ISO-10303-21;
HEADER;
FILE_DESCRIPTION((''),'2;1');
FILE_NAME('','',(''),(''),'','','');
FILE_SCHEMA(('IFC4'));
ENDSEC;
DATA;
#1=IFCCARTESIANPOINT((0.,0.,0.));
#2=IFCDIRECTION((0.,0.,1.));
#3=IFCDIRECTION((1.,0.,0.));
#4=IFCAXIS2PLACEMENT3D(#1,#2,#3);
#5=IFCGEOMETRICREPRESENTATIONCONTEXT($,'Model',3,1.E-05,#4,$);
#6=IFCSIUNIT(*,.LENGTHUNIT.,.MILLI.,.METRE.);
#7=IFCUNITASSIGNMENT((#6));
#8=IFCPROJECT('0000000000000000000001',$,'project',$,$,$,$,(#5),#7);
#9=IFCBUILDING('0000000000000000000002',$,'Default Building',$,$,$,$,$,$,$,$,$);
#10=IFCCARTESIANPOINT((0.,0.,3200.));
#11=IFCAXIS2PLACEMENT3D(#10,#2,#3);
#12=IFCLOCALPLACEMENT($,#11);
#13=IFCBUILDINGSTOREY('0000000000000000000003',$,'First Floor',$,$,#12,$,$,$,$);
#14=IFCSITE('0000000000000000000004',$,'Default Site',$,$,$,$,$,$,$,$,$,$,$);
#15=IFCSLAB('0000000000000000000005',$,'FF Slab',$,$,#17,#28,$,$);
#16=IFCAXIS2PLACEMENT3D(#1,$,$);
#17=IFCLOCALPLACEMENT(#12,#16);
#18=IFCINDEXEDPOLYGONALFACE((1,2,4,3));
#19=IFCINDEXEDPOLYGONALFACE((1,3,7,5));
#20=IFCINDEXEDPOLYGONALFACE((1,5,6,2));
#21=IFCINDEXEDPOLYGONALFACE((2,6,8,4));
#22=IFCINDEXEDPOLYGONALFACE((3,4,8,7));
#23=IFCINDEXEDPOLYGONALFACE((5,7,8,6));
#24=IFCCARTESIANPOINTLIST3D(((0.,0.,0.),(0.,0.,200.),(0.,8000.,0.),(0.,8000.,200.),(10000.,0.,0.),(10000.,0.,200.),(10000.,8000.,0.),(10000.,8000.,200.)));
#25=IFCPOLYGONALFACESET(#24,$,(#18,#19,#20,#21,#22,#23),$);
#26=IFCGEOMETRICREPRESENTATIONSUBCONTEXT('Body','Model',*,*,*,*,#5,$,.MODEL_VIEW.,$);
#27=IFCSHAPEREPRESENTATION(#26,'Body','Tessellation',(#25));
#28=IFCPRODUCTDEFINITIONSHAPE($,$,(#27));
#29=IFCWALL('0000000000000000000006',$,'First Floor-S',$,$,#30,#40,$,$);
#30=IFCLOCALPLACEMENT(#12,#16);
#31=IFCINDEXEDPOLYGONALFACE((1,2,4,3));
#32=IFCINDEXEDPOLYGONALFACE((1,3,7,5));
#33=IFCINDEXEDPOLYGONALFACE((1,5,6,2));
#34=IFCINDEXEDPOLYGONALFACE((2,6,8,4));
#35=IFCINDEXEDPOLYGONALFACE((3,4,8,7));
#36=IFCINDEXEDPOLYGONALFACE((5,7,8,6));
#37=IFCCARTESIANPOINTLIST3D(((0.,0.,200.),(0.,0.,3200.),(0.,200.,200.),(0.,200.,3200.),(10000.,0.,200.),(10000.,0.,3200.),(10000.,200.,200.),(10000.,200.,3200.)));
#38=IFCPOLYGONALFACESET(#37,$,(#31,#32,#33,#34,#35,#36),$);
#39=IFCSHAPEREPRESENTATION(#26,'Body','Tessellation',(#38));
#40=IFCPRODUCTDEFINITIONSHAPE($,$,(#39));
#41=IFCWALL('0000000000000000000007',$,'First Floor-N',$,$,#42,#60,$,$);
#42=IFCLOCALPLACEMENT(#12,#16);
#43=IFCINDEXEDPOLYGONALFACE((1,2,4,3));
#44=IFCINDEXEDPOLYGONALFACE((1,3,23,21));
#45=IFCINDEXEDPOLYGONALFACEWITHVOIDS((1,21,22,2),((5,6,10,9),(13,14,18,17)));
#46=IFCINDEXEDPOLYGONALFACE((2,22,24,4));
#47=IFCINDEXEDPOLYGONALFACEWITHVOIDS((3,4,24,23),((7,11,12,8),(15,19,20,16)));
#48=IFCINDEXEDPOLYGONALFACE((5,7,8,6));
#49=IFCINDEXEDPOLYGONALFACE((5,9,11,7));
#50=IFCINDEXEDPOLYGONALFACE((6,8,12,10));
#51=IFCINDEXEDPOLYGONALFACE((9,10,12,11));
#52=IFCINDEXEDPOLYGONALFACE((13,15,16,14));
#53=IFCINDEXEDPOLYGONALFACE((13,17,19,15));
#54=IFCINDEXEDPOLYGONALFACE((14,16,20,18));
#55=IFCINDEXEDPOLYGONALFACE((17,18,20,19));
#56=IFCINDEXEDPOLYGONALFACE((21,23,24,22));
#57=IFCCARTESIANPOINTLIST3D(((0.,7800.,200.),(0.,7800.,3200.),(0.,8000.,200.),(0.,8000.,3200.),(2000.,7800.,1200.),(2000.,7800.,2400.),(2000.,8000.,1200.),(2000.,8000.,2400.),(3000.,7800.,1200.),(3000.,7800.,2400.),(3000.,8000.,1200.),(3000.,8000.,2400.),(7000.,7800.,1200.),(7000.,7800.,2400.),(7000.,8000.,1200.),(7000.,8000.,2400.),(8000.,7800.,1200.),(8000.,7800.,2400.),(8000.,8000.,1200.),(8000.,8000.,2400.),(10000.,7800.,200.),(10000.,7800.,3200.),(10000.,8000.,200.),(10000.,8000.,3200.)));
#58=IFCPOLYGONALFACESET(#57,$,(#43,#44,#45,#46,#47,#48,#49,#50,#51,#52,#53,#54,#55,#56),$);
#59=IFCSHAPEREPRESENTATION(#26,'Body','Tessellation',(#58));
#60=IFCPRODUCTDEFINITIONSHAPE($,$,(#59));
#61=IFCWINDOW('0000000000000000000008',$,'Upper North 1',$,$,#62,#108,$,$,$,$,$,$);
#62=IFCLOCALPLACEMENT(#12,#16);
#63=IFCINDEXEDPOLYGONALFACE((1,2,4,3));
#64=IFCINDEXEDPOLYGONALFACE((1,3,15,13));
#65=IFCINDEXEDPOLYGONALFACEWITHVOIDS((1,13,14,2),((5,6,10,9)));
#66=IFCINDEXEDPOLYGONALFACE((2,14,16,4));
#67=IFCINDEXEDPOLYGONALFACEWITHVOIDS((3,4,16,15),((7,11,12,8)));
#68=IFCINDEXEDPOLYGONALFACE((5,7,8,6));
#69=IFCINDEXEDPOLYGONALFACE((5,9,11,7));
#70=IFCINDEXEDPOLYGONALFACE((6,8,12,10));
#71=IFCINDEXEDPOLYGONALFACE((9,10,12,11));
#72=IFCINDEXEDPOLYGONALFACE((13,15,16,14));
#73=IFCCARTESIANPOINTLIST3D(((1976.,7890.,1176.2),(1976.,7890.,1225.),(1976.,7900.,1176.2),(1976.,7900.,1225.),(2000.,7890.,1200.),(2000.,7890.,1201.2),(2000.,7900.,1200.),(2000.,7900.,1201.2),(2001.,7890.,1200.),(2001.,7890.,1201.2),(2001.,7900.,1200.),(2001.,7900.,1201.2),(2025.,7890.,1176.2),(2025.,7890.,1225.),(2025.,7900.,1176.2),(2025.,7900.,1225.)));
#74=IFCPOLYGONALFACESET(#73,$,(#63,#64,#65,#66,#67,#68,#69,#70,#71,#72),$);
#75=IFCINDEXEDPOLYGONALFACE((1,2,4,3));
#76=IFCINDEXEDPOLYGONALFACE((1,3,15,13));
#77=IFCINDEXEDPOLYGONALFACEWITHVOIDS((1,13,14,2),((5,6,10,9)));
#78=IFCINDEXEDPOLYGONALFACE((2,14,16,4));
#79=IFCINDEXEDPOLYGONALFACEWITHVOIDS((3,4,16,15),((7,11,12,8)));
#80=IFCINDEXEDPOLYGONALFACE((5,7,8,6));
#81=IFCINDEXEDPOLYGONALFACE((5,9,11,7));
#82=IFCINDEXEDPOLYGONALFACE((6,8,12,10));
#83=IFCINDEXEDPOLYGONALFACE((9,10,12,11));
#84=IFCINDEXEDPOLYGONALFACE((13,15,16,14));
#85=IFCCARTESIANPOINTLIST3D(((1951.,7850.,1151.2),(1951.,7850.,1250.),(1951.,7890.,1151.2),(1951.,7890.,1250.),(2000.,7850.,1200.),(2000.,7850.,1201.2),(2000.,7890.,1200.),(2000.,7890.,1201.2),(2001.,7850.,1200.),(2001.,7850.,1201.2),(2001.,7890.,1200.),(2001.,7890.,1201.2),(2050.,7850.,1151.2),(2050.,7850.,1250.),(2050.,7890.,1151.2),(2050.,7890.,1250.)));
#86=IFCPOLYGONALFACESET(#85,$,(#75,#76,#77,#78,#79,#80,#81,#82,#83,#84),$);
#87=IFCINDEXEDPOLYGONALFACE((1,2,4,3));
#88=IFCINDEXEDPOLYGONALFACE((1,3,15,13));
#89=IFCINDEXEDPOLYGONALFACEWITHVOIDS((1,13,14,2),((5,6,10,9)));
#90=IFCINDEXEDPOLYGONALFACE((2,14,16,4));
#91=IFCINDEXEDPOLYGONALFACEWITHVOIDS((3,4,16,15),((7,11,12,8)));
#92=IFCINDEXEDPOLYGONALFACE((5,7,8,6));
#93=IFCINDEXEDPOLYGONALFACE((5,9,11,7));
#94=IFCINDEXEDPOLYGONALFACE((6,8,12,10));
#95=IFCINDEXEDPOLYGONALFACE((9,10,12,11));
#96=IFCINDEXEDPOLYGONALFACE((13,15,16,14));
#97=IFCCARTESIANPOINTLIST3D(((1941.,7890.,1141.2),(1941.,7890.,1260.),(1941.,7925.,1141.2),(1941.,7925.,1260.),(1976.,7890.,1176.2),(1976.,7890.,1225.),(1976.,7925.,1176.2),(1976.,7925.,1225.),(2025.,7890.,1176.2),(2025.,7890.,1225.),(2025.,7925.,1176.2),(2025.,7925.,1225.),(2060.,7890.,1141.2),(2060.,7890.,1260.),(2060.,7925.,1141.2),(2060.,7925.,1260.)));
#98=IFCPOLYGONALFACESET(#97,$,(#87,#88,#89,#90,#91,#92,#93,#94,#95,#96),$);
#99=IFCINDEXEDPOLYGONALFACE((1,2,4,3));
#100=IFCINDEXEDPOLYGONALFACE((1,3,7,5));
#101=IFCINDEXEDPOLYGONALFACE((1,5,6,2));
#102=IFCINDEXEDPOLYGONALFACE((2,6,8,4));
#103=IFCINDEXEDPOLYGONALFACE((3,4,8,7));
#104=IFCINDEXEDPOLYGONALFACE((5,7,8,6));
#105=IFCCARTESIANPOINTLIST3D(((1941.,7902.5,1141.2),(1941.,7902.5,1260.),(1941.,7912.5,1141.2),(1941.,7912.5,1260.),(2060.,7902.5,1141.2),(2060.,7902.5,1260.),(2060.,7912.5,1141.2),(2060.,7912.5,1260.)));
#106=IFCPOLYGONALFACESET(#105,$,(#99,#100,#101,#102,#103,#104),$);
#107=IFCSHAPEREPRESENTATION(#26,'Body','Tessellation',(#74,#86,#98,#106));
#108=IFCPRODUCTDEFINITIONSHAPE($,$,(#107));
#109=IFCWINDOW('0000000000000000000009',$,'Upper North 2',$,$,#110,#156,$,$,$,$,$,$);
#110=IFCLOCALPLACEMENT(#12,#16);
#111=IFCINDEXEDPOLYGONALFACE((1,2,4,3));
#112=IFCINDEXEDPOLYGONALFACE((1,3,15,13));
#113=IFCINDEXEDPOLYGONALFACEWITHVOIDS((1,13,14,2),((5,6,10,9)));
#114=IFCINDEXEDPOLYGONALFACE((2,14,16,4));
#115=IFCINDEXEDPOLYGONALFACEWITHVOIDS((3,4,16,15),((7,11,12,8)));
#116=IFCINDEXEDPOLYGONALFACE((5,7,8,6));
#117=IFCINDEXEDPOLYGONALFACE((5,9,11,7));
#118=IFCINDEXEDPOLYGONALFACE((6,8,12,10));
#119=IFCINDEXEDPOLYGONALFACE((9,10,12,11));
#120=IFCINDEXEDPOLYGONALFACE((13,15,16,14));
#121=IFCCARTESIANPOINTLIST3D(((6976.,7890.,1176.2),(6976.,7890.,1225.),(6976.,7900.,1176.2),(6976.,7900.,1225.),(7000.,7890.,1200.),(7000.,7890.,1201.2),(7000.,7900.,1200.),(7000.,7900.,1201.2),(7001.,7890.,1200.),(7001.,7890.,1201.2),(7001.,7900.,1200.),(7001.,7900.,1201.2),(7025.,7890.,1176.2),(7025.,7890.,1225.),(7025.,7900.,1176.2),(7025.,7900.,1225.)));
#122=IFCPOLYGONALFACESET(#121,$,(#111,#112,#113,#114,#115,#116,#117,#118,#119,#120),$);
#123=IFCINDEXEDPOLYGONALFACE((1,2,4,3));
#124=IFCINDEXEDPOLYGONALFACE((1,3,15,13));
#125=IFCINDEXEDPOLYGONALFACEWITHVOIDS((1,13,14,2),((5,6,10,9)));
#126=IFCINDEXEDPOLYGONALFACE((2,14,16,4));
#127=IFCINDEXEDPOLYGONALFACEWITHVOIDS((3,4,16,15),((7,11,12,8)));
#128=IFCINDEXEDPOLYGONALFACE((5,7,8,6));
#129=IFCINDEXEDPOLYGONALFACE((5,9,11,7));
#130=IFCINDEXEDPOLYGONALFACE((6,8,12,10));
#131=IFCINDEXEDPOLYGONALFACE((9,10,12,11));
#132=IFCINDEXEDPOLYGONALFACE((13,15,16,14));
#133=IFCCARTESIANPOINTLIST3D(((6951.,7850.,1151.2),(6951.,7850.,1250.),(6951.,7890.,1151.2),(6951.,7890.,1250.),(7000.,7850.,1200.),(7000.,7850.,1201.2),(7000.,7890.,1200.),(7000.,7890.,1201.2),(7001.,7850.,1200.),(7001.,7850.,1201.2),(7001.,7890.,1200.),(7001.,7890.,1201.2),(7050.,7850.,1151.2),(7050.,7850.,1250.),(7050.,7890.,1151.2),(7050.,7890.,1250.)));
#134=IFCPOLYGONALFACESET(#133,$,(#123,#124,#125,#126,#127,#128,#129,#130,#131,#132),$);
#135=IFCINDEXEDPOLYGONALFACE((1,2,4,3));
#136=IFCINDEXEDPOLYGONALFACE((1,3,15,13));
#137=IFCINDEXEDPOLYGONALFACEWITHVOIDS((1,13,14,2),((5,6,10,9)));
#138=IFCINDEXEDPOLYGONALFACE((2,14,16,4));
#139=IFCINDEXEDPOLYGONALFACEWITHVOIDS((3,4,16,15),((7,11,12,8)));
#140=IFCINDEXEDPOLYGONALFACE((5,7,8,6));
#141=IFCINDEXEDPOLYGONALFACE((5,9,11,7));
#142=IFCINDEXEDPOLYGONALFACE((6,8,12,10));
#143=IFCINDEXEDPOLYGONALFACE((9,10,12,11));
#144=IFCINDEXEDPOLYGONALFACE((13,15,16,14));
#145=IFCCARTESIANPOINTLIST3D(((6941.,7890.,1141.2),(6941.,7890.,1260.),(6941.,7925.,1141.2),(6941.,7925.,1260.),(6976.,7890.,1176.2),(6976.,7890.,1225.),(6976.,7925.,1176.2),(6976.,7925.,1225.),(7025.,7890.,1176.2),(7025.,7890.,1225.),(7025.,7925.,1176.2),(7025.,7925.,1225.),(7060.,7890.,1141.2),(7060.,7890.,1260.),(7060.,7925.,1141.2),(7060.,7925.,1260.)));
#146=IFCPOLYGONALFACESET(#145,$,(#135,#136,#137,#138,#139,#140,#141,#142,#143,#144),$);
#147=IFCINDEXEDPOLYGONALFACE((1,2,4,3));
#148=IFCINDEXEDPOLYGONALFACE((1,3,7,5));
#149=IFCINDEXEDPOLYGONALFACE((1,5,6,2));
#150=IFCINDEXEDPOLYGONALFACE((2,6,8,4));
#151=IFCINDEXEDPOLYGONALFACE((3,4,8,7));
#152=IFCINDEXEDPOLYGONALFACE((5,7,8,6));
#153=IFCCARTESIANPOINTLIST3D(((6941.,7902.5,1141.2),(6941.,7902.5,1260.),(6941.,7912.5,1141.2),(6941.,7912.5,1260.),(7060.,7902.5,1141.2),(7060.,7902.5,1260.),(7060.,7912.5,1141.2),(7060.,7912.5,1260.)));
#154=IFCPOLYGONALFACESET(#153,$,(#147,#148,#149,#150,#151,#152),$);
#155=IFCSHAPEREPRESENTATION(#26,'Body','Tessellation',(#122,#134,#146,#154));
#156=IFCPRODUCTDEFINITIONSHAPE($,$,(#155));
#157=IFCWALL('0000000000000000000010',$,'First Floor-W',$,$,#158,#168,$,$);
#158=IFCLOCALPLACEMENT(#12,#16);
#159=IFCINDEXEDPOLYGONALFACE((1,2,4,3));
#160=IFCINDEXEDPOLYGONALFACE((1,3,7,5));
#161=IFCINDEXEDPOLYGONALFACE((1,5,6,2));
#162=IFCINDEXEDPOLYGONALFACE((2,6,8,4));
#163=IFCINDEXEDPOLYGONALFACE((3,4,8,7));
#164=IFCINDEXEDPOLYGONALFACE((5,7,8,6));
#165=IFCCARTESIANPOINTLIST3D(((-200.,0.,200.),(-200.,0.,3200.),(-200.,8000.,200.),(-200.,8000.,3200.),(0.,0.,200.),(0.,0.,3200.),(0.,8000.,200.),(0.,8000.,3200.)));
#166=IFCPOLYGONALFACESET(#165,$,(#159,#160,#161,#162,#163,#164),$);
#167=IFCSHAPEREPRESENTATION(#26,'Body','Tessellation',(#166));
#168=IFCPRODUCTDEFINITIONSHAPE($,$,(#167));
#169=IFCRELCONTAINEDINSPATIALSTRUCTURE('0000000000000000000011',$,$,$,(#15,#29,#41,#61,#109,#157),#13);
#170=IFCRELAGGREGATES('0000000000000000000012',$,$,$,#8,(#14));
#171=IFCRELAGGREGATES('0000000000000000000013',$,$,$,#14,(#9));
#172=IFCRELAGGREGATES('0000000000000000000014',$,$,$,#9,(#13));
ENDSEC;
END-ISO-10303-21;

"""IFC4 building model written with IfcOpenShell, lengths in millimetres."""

from ifc_helpers import new_model, si_unit, frame, origin_with_axes, place, context, subcontext, project, spatial, line, indexed_curve, outline, extrude, element, fill, save


model = new_model("IFC4")

# Units and contexts
model_context = context("Model", 3, precision=1e-05, world=origin_with_axes())
body_context = subcontext(model_context, "Body", "Model", "MODEL_VIEW")
ifc_project = project(units=[si_unit("LENGTHUNIT", "METRE", prefix="MILLI")], contexts=[model_context])

# Site, building, storey
site = spatial("IfcSite", under=ifc_project, Name="Default Site")
building = spatial("IfcBuilding", under=site, Name="Default Building")
storey_placement = place(None, frame((0.0, 0.0, 3200.0), z_axis=(0.0, 0.0, 1.0), x_axis=(1.0, 0.0, 0.0)))
storey = spatial("IfcBuildingStorey", under=building, at=storey_placement, Name="First Floor")

# Slab
slab_placement = place(storey_placement, origin_with_axes())
element("IfcSlab", 1, at=slab_placement, inside=storey, Name="FF Slab", context=body_context, shape_type="SweptSolid", body=[
    extrude(outline(indexed_curve([(0.0, 0.0), (10000.0, 0.0), (10000.0, 8000.0), (0.0, 8000.0), (0.0, 0.0)])), None, (0.0, 0.0, 1.0), 200.0),
])

# Wall
wall_1_placement = place(storey_placement, frame((0.0, 0.0, 200.0), z_axis=(0.0, 0.0, 1.0), x_axis=(1.0, 0.0, 0.0)))
element("IfcWall", 2, at=wall_1_placement, inside=storey, Name="First Floor-S", context=body_context, shape_type="SweptSolid", body=[
    extrude(outline(indexed_curve([(0.0, 0.0), (10000.0, 0.0), (10000.0, 200.0), (0.0, 200.0), (0.0, 0.0)])), None, (0.0, 0.0, 1.0), 3000.0),
])

# Wall, openings, windows
wall_2_placement = place(storey_placement, frame((0.0, 0.0, 200.0), z_axis=(0.0, 0.0, 1.0), x_axis=(1.0, 0.0, 0.0)))
wall_2 = element("IfcWall", 3, at=wall_2_placement, inside=storey, Name="First Floor-N", context=body_context, shape_type="SweptSolid", body=[
    extrude(outline(indexed_curve([(0.0, 7800.0), (10000.0, 7800.0), (10000.0, 8000.0), (0.0, 8000.0), (0.0, 7800.0)])), None, (0.0, 0.0, 1.0), 3000.0),
])
opening_1_placement = place(wall_2_placement, frame((0.0, 0.0, 1000.0), z_axis=(0.0, 0.0, 1.0), x_axis=(1.0, 0.0, 0.0)))
opening_1 = element("IfcOpeningElement", 4, at=opening_1_placement, cuts=wall_2, context=body_context, shape_type="SweptSolid", body=[
    extrude(outline(indexed_curve([(2000.0, 7800.0), (3000.0, 7800.0), (3000.0, 8000.0), (2000.0, 8000.0), (2000.0, 7800.0)])), None, (0.0, 0.0, 1.0), 1200.0),
])
opening_2_placement = place(wall_2_placement, frame((0.0, 0.0, 1000.0), z_axis=(0.0, 0.0, 1.0), x_axis=(1.0, 0.0, 0.0)))
opening_2 = element("IfcOpeningElement", 5, at=opening_2_placement, cuts=wall_2, context=body_context, shape_type="SweptSolid", body=[
    extrude(outline(indexed_curve([(7000.0, 7800.0), (8000.0, 7800.0), (8000.0, 8000.0), (7000.0, 8000.0), (7000.0, 7800.0)])), None, (0.0, 0.0, 1.0), 1200.0),
])
window_1_placement = place(storey_placement, frame((2000.0, 7800.0, 1200.0), z_axis=(0.0, 0.0, 1.0), x_axis=(1.0, 0.0, 0.0)))
window_1 = element("IfcWindow", 6, at=window_1_placement, inside=storey, Name="Upper North 1", context=body_context, shape_type="SweptSolid", body=[
    extrude(outline(indexed_curve([(0.0, 0.0), (1.0, 0.0), (1.0, 1.2), (0.0, 1.2)], segments=[line(1, 2, 3, 4, 1)]), holes=[indexed_curve([(25.0, 25.0), (-24.0, 25.0), (-24.0, -23.8), (25.0, -23.8)], segments=[line(1, 2, 3, 4, 1)])]), frame((0.0, 90.0, 0.0), z_axis=(0.0, -1.0, 0.0), x_axis=(1.0, 0.0, 0.0)), (0.0, 0.0, -1.0), 10.0),
    extrude(outline(indexed_curve([(0.0, 0.0), (1.0, 0.0), (1.0, 1.2), (0.0, 1.2)], segments=[line(1, 2, 3, 4, 1)]), holes=[indexed_curve([(50.0, 50.0), (-49.0, 50.0), (-49.0, -48.8), (50.0, -48.8)], segments=[line(1, 2, 3, 4, 1)])]), frame((0.0, 50.0, 0.0), z_axis=(0.0, -1.0, 0.0), x_axis=(1.0, 0.0, 0.0)), (0.0, 0.0, -1.0), 40.0),
    extrude(outline(indexed_curve([(0.0, 0.0), (-49.0, 0.0), (-49.0, -48.8), (0.0, -48.8)], segments=[line(1, 2, 3, 4, 1)]), holes=[indexed_curve([(35.0, 35.0), (-84.0, 35.0), (-84.0, -83.8), (35.0, -83.8)], segments=[line(1, 2, 3, 4, 1)])]), frame((25.0, 90.0, 25.0), z_axis=(0.0, -1.0, 0.0), x_axis=(1.0, 0.0, 0.0)), (0.0, 0.0, -1.0), 35.0),
    extrude(outline(indexed_curve([(35.0, 35.0), (-84.0, 35.0), (-84.0, -83.8), (35.0, -83.8)], segments=[line(1, 2, 3, 4, 1)])), frame((25.0, 102.5, 25.0), z_axis=(0.0, -1.0, 0.0), x_axis=(1.0, 0.0, 0.0)), (0.0, 0.0, -1.0), 10.0),
])
fill(opening_1, window_1)
window_2_placement = place(storey_placement, frame((7000.0, 7800.0, 1200.0), z_axis=(0.0, 0.0, 1.0), x_axis=(1.0, 0.0, 0.0)))
window_2 = element("IfcWindow", 7, at=window_2_placement, inside=storey, Name="Upper North 2", context=body_context, shape_type="SweptSolid", body=[
    extrude(outline(indexed_curve([(0.0, 0.0), (1.0, 0.0), (1.0, 1.2), (0.0, 1.2)], segments=[line(1, 2, 3, 4, 1)]), holes=[indexed_curve([(25.0, 25.0), (-24.0, 25.0), (-24.0, -23.8), (25.0, -23.8)], segments=[line(1, 2, 3, 4, 1)])]), frame((0.0, 90.0, 0.0), z_axis=(0.0, -1.0, 0.0), x_axis=(1.0, 0.0, 0.0)), (0.0, 0.0, -1.0), 10.0),
    extrude(outline(indexed_curve([(0.0, 0.0), (1.0, 0.0), (1.0, 1.2), (0.0, 1.2)], segments=[line(1, 2, 3, 4, 1)]), holes=[indexed_curve([(50.0, 50.0), (-49.0, 50.0), (-49.0, -48.8), (50.0, -48.8)], segments=[line(1, 2, 3, 4, 1)])]), frame((0.0, 50.0, 0.0), z_axis=(0.0, -1.0, 0.0), x_axis=(1.0, 0.0, 0.0)), (0.0, 0.0, -1.0), 40.0),
    extrude(outline(indexed_curve([(0.0, 0.0), (-49.0, 0.0), (-49.0, -48.8), (0.0, -48.8)], segments=[line(1, 2, 3, 4, 1)]), holes=[indexed_curve([(35.0, 35.0), (-84.0, 35.0), (-84.0, -83.8), (35.0, -83.8)], segments=[line(1, 2, 3, 4, 1)])]), frame((25.0, 90.0, 25.0), z_axis=(0.0, -1.0, 0.0), x_axis=(1.0, 0.0, 0.0)), (0.0, 0.0, -1.0), 35.0),
    extrude(outline(indexed_curve([(35.0, 35.0), (-84.0, 35.0), (-84.0, -83.8), (35.0, -83.8)], segments=[line(1, 2, 3, 4, 1)])), frame((25.0, 102.5, 25.0), z_axis=(0.0, -1.0, 0.0), x_axis=(1.0, 0.0, 0.0)), (0.0, 0.0, -1.0), 10.0),
])
fill(opening_2, window_2)

# Wall
wall_3_placement = place(storey_placement, frame((0.0, 0.0, 200.0), z_axis=(0.0, 0.0, 1.0), x_axis=(1.0, 0.0, 0.0)))
element("IfcWall", 8, at=wall_3_placement, inside=storey, Name="First Floor-W", context=body_context, shape_type="SweptSolid", body=[
    extrude(outline(indexed_curve([(0.0, 0.0), (0.0, 8000.0), (-200.0, 8000.0), (-200.0, 0.0), (0.0, 0.0)])), None, (0.0, 0.0, 1.0), 3000.0),
])

save(model, "model.ifc")
